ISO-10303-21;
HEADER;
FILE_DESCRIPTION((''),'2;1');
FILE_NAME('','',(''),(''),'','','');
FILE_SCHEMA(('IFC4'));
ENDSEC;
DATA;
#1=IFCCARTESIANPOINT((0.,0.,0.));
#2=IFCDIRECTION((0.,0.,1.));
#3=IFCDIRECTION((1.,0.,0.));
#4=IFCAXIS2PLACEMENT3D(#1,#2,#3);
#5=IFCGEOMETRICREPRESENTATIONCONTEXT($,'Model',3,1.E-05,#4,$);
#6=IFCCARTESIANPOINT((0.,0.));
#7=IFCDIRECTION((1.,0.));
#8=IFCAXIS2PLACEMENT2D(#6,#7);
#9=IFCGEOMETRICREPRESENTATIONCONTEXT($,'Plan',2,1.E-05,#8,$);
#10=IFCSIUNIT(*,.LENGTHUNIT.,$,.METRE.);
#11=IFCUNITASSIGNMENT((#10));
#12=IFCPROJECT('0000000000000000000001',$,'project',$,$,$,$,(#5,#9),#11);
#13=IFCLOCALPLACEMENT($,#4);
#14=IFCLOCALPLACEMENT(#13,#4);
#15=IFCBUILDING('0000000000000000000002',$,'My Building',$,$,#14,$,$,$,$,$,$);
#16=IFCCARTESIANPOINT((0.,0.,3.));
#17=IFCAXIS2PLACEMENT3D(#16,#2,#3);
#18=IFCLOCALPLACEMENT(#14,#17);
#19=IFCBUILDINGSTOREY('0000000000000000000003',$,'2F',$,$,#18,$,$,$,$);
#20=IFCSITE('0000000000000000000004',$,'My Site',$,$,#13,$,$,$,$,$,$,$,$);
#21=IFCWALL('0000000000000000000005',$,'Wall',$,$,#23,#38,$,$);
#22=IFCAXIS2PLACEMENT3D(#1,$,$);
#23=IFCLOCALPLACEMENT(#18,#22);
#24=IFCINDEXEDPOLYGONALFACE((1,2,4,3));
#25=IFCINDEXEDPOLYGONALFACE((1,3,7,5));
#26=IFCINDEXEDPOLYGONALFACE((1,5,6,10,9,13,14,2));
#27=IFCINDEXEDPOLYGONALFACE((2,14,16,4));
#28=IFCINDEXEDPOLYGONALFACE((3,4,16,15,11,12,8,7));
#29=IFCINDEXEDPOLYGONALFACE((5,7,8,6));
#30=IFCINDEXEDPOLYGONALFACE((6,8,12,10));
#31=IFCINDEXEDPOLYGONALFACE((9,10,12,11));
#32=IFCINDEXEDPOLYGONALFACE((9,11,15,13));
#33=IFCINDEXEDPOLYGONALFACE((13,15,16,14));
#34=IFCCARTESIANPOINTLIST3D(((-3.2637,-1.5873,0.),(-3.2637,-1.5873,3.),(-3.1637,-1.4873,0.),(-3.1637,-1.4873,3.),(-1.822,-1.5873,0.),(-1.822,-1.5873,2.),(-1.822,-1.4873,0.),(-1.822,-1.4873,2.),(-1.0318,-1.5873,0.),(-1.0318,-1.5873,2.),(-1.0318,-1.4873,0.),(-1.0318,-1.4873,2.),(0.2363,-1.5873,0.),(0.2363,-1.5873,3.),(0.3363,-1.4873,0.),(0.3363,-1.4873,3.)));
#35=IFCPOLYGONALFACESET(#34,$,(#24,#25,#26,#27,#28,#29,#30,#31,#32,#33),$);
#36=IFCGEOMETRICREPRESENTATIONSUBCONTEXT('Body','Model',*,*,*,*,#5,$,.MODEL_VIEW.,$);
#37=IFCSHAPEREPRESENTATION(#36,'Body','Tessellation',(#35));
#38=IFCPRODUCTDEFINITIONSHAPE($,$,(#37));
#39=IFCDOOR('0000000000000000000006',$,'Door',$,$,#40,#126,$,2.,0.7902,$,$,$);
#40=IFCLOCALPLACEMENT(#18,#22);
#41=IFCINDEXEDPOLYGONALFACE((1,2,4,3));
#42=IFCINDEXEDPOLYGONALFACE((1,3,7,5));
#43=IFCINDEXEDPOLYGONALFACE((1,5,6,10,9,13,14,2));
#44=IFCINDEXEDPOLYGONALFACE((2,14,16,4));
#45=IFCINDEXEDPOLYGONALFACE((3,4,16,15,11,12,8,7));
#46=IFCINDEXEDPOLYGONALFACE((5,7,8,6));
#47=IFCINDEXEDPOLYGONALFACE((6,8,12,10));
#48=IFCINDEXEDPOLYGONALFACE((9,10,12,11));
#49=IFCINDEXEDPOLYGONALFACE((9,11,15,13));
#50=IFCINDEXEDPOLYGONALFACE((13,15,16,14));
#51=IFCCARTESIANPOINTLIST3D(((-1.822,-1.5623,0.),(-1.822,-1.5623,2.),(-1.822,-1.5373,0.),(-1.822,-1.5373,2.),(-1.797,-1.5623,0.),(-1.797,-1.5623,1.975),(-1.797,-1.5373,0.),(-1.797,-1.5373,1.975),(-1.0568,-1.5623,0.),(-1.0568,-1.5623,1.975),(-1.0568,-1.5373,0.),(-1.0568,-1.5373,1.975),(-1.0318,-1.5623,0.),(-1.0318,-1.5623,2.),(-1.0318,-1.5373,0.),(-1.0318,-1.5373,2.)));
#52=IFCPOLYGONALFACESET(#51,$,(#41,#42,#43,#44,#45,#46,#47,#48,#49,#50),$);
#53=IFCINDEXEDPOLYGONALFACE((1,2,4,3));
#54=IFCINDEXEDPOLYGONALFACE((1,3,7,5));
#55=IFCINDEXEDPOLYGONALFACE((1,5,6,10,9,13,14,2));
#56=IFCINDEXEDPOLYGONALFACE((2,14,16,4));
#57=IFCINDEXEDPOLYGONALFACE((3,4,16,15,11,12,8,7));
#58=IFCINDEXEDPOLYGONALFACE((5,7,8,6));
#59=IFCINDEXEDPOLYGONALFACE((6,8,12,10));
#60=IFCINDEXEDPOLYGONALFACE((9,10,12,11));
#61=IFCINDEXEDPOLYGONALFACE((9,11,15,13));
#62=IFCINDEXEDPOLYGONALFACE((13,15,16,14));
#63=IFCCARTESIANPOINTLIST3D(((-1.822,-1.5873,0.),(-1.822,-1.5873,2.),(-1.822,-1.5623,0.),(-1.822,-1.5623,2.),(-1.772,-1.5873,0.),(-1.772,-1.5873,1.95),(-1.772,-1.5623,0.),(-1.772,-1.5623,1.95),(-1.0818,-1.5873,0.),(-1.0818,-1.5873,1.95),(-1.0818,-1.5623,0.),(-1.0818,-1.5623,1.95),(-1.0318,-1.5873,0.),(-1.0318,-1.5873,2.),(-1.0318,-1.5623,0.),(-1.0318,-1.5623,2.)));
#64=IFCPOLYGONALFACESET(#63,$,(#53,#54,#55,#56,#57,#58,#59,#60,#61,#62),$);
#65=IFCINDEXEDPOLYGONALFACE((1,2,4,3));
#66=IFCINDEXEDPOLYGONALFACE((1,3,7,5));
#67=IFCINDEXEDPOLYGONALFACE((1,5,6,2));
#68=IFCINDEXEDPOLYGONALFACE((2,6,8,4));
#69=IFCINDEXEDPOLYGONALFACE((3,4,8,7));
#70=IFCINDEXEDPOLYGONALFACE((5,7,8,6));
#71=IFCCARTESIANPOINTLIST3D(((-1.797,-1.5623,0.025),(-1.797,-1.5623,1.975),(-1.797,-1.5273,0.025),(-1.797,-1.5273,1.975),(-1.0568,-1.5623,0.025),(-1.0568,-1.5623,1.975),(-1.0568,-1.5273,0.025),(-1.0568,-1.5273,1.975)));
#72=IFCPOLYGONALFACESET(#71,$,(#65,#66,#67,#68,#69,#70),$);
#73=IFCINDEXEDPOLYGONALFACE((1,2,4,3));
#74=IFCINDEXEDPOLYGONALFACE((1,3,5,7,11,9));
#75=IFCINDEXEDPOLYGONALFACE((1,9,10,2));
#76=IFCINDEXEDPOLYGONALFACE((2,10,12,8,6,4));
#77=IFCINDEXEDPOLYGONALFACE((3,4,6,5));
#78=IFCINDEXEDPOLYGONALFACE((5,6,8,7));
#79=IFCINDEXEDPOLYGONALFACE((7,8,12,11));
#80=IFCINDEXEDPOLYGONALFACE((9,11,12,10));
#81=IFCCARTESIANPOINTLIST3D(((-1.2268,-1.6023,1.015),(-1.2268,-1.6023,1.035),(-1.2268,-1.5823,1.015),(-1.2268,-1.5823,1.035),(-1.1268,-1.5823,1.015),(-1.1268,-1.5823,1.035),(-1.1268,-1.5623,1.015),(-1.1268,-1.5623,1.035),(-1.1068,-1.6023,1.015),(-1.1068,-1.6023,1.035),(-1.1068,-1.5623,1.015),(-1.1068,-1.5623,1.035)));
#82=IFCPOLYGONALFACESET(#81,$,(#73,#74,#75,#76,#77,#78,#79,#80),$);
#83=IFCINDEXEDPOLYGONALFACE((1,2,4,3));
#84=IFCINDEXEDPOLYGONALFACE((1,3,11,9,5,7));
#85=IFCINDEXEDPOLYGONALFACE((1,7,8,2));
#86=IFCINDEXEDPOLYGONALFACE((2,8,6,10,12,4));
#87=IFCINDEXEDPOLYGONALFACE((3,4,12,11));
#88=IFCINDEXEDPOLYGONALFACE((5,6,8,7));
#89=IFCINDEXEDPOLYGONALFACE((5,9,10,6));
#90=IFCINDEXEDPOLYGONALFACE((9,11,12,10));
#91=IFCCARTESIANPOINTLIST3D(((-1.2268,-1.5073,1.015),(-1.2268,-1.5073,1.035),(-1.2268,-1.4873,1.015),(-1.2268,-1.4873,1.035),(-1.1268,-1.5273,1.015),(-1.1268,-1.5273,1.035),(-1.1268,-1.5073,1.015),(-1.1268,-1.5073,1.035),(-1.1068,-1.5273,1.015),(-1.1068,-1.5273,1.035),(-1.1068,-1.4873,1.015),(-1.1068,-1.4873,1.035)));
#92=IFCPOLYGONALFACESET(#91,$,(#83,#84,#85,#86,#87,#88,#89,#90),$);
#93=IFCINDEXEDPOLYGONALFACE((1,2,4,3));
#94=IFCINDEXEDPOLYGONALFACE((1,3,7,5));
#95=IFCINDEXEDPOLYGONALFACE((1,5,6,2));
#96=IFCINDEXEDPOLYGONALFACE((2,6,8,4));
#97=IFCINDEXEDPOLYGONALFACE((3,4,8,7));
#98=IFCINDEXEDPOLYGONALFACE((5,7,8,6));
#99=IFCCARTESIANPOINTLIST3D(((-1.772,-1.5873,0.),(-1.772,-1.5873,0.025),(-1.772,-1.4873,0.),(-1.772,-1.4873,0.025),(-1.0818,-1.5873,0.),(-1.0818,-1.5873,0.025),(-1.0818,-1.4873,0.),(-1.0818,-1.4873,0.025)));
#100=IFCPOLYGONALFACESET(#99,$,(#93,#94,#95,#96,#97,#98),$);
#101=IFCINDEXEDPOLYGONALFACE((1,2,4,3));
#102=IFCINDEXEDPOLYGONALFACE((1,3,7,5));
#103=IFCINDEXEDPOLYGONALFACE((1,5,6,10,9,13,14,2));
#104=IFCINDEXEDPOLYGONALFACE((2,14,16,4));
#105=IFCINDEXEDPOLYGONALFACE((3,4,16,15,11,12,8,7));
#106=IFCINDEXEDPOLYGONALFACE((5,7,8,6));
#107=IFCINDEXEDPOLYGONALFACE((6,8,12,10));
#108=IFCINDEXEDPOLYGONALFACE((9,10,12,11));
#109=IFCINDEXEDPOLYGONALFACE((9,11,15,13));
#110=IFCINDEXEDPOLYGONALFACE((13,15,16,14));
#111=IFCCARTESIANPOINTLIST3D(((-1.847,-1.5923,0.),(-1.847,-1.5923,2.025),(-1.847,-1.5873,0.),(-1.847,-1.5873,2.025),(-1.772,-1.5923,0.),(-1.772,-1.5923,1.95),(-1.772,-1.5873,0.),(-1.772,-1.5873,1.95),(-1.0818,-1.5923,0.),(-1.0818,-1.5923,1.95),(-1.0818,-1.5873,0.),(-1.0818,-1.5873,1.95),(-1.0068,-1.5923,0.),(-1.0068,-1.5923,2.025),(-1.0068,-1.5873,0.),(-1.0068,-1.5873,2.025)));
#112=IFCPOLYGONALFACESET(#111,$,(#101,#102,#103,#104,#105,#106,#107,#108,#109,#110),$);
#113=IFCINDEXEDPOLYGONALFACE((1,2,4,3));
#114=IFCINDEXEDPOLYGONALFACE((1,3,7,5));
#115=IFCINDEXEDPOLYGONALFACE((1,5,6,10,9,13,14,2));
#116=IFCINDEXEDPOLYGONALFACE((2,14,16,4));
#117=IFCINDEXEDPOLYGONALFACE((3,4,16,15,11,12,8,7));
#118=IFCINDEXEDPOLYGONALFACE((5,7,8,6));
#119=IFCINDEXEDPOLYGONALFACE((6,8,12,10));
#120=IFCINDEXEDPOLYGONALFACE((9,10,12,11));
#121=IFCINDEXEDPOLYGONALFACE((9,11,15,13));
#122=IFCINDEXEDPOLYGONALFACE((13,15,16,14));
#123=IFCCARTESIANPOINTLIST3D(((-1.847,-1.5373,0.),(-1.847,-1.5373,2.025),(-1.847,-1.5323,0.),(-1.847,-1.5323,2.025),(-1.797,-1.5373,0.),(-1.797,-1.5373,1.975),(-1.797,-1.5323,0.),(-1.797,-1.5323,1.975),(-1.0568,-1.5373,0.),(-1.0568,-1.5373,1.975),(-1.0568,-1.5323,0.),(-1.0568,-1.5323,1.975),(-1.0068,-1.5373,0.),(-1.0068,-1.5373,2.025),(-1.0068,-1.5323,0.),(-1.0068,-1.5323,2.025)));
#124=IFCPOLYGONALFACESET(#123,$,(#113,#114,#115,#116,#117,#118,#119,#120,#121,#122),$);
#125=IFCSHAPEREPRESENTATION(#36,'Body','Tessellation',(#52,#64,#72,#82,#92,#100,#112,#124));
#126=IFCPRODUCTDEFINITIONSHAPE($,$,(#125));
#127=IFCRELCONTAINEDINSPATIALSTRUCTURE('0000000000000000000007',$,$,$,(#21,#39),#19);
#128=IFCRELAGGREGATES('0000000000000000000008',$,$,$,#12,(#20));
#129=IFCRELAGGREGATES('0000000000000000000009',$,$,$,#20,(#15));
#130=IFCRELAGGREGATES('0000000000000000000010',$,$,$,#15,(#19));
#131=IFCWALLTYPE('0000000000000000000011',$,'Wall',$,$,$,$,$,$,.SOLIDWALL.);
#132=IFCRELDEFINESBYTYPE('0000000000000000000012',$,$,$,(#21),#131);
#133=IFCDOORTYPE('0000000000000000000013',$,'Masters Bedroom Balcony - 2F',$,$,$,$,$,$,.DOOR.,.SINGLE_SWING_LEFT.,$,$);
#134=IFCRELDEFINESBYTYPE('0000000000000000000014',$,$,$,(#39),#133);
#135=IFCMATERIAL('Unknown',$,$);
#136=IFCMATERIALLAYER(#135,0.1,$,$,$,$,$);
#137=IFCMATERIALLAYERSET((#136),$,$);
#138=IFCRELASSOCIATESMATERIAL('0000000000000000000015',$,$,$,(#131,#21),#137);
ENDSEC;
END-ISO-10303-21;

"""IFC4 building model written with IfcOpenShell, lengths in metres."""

from ifc_helpers import new_model, entity, si_unit, frame, origin_with_axes, origin_2d_with_axis, place, context, subcontext, project, spatial, line, indexed_curve, outline, extrude, shape, source, transform, mapped, material, layer, layer_set, layer_usage, type_object, type_shapes, element, fill, save


model = new_model("IFC4")

# Units and contexts
model_context = context("Model", 3, precision=1e-05, world=origin_with_axes())
plan_context = context("Plan", 2, precision=1e-05, world=origin_2d_with_axis())
body_context_1 = subcontext(model_context, "Body", "Model", "MODEL_VIEW")
body_context_2 = subcontext(plan_context, "Body", "Plan", "PLAN_VIEW")
ifc_project = project(units=[si_unit("LENGTHUNIT", "METRE")], contexts=[model_context, plan_context])

# Site, building, storey
site_placement = place(None, origin_with_axes())
site = spatial("IfcSite", under=ifc_project, at=site_placement, Name="My Site")
building_placement = place(site_placement, origin_with_axes())
building = spatial("IfcBuilding", under=site, at=building_placement, Name="My Building")
storey_placement = place(building_placement, frame((0.0, 0.0, 3.0), z_axis=(0.0, 0.0, 1.0), x_axis=(1.0, 0.0, 0.0)))
storey = spatial("IfcBuildingStorey", under=building, at=storey_placement, Name="2F")

# Shared definitions
ifc_material = material(Name="Unknown")

# Shared definitions
ifc_layer_1 = layer(ifc_material, 0.1)
ifc_layer_set_1 = layer_set([ifc_layer_1])
wall_type = type_object("IfcWallType", Name="Wall", PredefinedType="SOLIDWALL", material=ifc_layer_set_1)

# Wall, opening, door
ifc_layer_usage_1 = layer_usage(ifc_layer_set_1, "AXIS2", "POSITIVE", 0.0)
wall_1_placement = place(storey_placement, frame((-3.2637, -1.5873, 0.0), z_axis=(0.0, 0.0, 1.0), x_axis=(1.0, 0.0, 0.0)))
wall_1 = element("IfcWall", 1, at=wall_1_placement, inside=storey, type_object=wall_type, material=ifc_layer_usage_1, Name="Wall", context=body_context_1, shape_type="SweptSolid", body=[
    extrude(outline(indexed_curve([(0.0, 0.0), (0.1, 0.1), (3.6, 0.1), (3.5, 0.0)], segments=[line(1, 2, 3, 4, 1)])), origin_with_axes(), (0.0, 0.0, 1.0), 3.0),
])
shared_shape_1 = source(origin_with_axes(), body_context_1, "Body", "SweptSolid", [
    extrude(outline(indexed_curve([(0.0, 0.0), (0.7902, 0.0), (0.7902, 2.0), (0.0, 2.0)], segments=[line(1, 2, 3, 4, 1)])), frame((0.0, -0.6, 0.0), z_axis=(0.0, -1.0, 0.0), x_axis=(1.0, 0.0, 0.0)), (0.0, 0.0, -1.0), 1.2),
])
opening_1_placement = place(wall_1_placement, frame((1.4417, 0.0, 0.0), z_axis=(0.0, 0.0, 1.0), x_axis=(1.0, 0.0, 0.0)))
opening_1 = element("IfcOpeningElement", 2, at=opening_1_placement, cuts=wall_1, PredefinedType="OPENING", context=body_context_1, shape_type="MappedRepresentation", body=[
    mapped(shared_shape_1, transform((0.0, 0.0, 0.0), x_axis=(1.0, 0.0, 0.0), y_axis=(0.0, 1.0, 0.0), z_axis=(0.0, 0.0, 1.0), scale=1.0)),
])
door_type_1 = type_object("IfcDoorType", Name="Masters Bedroom Balcony - 2F", OperationType="SINGLE_SWING_LEFT", PredefinedType="DOOR")
shared_shape_2 = source(origin_with_axes(), body_context_1, "Body", "SweptSolid", [
    extrude(outline(indexed_curve([(0.0, 0.0), (0.0, 2.0), (0.7902, 2.0), (0.7902, 0.0), (0.7652, 0.0), (0.7652, 1.975), (0.025, 1.975), (0.025, 0.0)], segments=[line(1, 2, 3, 4, 5, 6, 7, 8, 1)])), frame((0.0, 0.025, 0.0), z_axis=(0.0, -1.0, 0.0), x_axis=(1.0, 0.0, 0.0)), (0.0, 0.0, -1.0), 0.025),
    extrude(outline(indexed_curve([(0.0, 0.0), (0.0, 2.0), (0.7902, 2.0), (0.7902, 0.0), (0.7402, 0.0), (0.7402, 1.95), (0.05, 1.95), (0.05, 0.0)], segments=[line(1, 2, 3, 4, 5, 6, 7, 8, 1)])), frame((0.0, 0.0, 0.0), z_axis=(0.0, -1.0, 0.0), x_axis=(1.0, 0.0, 0.0)), (0.0, 0.0, -1.0), 0.025),
    extrude(outline(indexed_curve([(0.0, 0.0), (0.7402, 0.0), (0.7402, 0.035), (0.0, 0.035)], segments=[line(1, 2, 3, 4, 1)])), frame((0.025, 0.025, 0.025), z_axis=(0.0, 0.0, 1.0), x_axis=(1.0, 0.0, 0.0)), (0.0, 0.0, 1.0), 1.95),
    extrude(outline(indexed_curve([(0.0, 0.0), (0.0, -0.04), (-0.12, -0.04), (-0.12, -0.02), (-0.02, -0.02), (-0.02, 0.0)], segments=[line(1, 2, 3, 4, 5, 6, 1)])), frame((0.7152, 0.025, 1.015), z_axis=(0.0, 0.0, 1.0), x_axis=(1.0, 0.0, 0.0)), (0.0, 0.0, 1.0), 0.02),
    extrude(outline(indexed_curve([(0.0, 0.0), (0.0, 0.04), (-0.12, 0.04), (-0.12, 0.02), (-0.02, 0.02), (-0.02, 0.0)], segments=[line(1, 2, 3, 4, 5, 6, 1)])), frame((0.7152, 0.06, 1.015), z_axis=(0.0, 0.0, 1.0), x_axis=(1.0, 0.0, 0.0)), (0.0, 0.0, 1.0), 0.02),
    extrude(outline(indexed_curve([(0.0, 0.0), (0.6902, 0.0), (0.6902, 0.1), (0.0, 0.1)], segments=[line(1, 2, 3, 4, 1)])), frame((0.05, 0.0, 0.0), z_axis=(0.0, 0.0, 1.0), x_axis=(1.0, 0.0, 0.0)), (0.0, 0.0, 1.0), 0.025),
    extrude(outline(indexed_curve([(0.0, 0.0), (0.0, 2.025), (0.8402, 2.025), (0.8402, 0.0), (0.7652, 0.0), (0.7652, 1.95), (0.075, 1.95), (0.075, 0.0)], segments=[line(1, 2, 3, 4, 5, 6, 7, 8, 1)])), frame((-0.025, -0.005, 0.0), z_axis=(0.0, -1.0, 0.0), x_axis=(1.0, 0.0, 0.0)), (0.0, 0.0, -1.0), 0.005),
    extrude(outline(indexed_curve([(0.0, 0.0), (0.0, 2.025), (0.8402, 2.025), (0.8402, 0.0), (0.7902, 0.0), (0.7902, 1.975), (0.05, 1.975), (0.05, 0.0)], segments=[line(1, 2, 3, 4, 5, 6, 7, 8, 1)])), frame((-0.025, 0.05, 0.0), z_axis=(0.0, -1.0, 0.0), x_axis=(1.0, 0.0, 0.0)), (0.0, 0.0, -1.0), 0.005),
])
shared_shape_3 = source(origin_with_axes(), body_context_2, "Body", "Curve2D", [
    entity("IfcIndexedPolyCurve", entity("IfcCartesianPointList2D", [[0.0, 0.0], [0.0, 0.05], [0.025, 0.05], [0.025, 0.025], [0.05, 0.025], [0.05, 0.0]]), [entity("IfcLineIndex", [1, 2, 3, 4, 5, 6, 1])]),
    entity("IfcIndexedPolyCurve", entity("IfcCartesianPointList2D", [[0.7902, 0.0], [0.7902, 0.05], [0.7652, 0.05], [0.7652, 0.025], [0.7402, 0.025], [0.7402, 0.0]]), [entity("IfcLineIndex", [1, 2, 3, 4, 5, 6, 1])]),
    entity("IfcTrimmedCurve", entity("IfcEllipse", entity("IfcAxis2Placement2D", entity("IfcCartesianPoint", [0.06, 0.05]), entity("IfcDirection", [1.0, 0.0])), 0.7052, 0.7402), [entity("IfcCartesianPoint", [0.7652, 0.05])], [entity("IfcCartesianPoint", [0.06, 0.7902])], True, "CARTESIAN"),
    entity("IfcIndexedPolyCurve", entity("IfcCartesianPointList2D", [[0.025, 0.05], [0.06, 0.05], [0.06, 0.7902], [0.025, 0.7902]]), [entity("IfcLineIndex", [1, 2, 3, 4, 1])]),
])
type_shapes(door_type_1, [shared_shape_2, shared_shape_3])
door_1_placement = place(opening_1_placement, origin_with_axes())
door_1 = element("IfcDoor", 3, at=door_1_placement, inside=storey, type_object=door_type_1, Name="Door", OverallHeight=2.0, OverallWidth=0.7902, shapes=[
    shape(body_context_1, "Body", "MappedRepresentation", [mapped(shared_shape_2, transform((0.0, 0.0, 0.0), x_axis=(1.0, 0.0, 0.0), y_axis=(0.0, 1.0, 0.0), z_axis=(0.0, 0.0, 1.0), scale=1.0))]),
    shape(body_context_2, "Body", "MappedRepresentation", [mapped(shared_shape_3, transform((0.0, 0.0, 0.0), x_axis=(1.0, 0.0, 0.0), y_axis=(0.0, 1.0, 0.0), z_axis=(0.0, 0.0, 1.0), scale=1.0))]),
])
fill(opening_1, door_1)

save(model, "model.ifc")
